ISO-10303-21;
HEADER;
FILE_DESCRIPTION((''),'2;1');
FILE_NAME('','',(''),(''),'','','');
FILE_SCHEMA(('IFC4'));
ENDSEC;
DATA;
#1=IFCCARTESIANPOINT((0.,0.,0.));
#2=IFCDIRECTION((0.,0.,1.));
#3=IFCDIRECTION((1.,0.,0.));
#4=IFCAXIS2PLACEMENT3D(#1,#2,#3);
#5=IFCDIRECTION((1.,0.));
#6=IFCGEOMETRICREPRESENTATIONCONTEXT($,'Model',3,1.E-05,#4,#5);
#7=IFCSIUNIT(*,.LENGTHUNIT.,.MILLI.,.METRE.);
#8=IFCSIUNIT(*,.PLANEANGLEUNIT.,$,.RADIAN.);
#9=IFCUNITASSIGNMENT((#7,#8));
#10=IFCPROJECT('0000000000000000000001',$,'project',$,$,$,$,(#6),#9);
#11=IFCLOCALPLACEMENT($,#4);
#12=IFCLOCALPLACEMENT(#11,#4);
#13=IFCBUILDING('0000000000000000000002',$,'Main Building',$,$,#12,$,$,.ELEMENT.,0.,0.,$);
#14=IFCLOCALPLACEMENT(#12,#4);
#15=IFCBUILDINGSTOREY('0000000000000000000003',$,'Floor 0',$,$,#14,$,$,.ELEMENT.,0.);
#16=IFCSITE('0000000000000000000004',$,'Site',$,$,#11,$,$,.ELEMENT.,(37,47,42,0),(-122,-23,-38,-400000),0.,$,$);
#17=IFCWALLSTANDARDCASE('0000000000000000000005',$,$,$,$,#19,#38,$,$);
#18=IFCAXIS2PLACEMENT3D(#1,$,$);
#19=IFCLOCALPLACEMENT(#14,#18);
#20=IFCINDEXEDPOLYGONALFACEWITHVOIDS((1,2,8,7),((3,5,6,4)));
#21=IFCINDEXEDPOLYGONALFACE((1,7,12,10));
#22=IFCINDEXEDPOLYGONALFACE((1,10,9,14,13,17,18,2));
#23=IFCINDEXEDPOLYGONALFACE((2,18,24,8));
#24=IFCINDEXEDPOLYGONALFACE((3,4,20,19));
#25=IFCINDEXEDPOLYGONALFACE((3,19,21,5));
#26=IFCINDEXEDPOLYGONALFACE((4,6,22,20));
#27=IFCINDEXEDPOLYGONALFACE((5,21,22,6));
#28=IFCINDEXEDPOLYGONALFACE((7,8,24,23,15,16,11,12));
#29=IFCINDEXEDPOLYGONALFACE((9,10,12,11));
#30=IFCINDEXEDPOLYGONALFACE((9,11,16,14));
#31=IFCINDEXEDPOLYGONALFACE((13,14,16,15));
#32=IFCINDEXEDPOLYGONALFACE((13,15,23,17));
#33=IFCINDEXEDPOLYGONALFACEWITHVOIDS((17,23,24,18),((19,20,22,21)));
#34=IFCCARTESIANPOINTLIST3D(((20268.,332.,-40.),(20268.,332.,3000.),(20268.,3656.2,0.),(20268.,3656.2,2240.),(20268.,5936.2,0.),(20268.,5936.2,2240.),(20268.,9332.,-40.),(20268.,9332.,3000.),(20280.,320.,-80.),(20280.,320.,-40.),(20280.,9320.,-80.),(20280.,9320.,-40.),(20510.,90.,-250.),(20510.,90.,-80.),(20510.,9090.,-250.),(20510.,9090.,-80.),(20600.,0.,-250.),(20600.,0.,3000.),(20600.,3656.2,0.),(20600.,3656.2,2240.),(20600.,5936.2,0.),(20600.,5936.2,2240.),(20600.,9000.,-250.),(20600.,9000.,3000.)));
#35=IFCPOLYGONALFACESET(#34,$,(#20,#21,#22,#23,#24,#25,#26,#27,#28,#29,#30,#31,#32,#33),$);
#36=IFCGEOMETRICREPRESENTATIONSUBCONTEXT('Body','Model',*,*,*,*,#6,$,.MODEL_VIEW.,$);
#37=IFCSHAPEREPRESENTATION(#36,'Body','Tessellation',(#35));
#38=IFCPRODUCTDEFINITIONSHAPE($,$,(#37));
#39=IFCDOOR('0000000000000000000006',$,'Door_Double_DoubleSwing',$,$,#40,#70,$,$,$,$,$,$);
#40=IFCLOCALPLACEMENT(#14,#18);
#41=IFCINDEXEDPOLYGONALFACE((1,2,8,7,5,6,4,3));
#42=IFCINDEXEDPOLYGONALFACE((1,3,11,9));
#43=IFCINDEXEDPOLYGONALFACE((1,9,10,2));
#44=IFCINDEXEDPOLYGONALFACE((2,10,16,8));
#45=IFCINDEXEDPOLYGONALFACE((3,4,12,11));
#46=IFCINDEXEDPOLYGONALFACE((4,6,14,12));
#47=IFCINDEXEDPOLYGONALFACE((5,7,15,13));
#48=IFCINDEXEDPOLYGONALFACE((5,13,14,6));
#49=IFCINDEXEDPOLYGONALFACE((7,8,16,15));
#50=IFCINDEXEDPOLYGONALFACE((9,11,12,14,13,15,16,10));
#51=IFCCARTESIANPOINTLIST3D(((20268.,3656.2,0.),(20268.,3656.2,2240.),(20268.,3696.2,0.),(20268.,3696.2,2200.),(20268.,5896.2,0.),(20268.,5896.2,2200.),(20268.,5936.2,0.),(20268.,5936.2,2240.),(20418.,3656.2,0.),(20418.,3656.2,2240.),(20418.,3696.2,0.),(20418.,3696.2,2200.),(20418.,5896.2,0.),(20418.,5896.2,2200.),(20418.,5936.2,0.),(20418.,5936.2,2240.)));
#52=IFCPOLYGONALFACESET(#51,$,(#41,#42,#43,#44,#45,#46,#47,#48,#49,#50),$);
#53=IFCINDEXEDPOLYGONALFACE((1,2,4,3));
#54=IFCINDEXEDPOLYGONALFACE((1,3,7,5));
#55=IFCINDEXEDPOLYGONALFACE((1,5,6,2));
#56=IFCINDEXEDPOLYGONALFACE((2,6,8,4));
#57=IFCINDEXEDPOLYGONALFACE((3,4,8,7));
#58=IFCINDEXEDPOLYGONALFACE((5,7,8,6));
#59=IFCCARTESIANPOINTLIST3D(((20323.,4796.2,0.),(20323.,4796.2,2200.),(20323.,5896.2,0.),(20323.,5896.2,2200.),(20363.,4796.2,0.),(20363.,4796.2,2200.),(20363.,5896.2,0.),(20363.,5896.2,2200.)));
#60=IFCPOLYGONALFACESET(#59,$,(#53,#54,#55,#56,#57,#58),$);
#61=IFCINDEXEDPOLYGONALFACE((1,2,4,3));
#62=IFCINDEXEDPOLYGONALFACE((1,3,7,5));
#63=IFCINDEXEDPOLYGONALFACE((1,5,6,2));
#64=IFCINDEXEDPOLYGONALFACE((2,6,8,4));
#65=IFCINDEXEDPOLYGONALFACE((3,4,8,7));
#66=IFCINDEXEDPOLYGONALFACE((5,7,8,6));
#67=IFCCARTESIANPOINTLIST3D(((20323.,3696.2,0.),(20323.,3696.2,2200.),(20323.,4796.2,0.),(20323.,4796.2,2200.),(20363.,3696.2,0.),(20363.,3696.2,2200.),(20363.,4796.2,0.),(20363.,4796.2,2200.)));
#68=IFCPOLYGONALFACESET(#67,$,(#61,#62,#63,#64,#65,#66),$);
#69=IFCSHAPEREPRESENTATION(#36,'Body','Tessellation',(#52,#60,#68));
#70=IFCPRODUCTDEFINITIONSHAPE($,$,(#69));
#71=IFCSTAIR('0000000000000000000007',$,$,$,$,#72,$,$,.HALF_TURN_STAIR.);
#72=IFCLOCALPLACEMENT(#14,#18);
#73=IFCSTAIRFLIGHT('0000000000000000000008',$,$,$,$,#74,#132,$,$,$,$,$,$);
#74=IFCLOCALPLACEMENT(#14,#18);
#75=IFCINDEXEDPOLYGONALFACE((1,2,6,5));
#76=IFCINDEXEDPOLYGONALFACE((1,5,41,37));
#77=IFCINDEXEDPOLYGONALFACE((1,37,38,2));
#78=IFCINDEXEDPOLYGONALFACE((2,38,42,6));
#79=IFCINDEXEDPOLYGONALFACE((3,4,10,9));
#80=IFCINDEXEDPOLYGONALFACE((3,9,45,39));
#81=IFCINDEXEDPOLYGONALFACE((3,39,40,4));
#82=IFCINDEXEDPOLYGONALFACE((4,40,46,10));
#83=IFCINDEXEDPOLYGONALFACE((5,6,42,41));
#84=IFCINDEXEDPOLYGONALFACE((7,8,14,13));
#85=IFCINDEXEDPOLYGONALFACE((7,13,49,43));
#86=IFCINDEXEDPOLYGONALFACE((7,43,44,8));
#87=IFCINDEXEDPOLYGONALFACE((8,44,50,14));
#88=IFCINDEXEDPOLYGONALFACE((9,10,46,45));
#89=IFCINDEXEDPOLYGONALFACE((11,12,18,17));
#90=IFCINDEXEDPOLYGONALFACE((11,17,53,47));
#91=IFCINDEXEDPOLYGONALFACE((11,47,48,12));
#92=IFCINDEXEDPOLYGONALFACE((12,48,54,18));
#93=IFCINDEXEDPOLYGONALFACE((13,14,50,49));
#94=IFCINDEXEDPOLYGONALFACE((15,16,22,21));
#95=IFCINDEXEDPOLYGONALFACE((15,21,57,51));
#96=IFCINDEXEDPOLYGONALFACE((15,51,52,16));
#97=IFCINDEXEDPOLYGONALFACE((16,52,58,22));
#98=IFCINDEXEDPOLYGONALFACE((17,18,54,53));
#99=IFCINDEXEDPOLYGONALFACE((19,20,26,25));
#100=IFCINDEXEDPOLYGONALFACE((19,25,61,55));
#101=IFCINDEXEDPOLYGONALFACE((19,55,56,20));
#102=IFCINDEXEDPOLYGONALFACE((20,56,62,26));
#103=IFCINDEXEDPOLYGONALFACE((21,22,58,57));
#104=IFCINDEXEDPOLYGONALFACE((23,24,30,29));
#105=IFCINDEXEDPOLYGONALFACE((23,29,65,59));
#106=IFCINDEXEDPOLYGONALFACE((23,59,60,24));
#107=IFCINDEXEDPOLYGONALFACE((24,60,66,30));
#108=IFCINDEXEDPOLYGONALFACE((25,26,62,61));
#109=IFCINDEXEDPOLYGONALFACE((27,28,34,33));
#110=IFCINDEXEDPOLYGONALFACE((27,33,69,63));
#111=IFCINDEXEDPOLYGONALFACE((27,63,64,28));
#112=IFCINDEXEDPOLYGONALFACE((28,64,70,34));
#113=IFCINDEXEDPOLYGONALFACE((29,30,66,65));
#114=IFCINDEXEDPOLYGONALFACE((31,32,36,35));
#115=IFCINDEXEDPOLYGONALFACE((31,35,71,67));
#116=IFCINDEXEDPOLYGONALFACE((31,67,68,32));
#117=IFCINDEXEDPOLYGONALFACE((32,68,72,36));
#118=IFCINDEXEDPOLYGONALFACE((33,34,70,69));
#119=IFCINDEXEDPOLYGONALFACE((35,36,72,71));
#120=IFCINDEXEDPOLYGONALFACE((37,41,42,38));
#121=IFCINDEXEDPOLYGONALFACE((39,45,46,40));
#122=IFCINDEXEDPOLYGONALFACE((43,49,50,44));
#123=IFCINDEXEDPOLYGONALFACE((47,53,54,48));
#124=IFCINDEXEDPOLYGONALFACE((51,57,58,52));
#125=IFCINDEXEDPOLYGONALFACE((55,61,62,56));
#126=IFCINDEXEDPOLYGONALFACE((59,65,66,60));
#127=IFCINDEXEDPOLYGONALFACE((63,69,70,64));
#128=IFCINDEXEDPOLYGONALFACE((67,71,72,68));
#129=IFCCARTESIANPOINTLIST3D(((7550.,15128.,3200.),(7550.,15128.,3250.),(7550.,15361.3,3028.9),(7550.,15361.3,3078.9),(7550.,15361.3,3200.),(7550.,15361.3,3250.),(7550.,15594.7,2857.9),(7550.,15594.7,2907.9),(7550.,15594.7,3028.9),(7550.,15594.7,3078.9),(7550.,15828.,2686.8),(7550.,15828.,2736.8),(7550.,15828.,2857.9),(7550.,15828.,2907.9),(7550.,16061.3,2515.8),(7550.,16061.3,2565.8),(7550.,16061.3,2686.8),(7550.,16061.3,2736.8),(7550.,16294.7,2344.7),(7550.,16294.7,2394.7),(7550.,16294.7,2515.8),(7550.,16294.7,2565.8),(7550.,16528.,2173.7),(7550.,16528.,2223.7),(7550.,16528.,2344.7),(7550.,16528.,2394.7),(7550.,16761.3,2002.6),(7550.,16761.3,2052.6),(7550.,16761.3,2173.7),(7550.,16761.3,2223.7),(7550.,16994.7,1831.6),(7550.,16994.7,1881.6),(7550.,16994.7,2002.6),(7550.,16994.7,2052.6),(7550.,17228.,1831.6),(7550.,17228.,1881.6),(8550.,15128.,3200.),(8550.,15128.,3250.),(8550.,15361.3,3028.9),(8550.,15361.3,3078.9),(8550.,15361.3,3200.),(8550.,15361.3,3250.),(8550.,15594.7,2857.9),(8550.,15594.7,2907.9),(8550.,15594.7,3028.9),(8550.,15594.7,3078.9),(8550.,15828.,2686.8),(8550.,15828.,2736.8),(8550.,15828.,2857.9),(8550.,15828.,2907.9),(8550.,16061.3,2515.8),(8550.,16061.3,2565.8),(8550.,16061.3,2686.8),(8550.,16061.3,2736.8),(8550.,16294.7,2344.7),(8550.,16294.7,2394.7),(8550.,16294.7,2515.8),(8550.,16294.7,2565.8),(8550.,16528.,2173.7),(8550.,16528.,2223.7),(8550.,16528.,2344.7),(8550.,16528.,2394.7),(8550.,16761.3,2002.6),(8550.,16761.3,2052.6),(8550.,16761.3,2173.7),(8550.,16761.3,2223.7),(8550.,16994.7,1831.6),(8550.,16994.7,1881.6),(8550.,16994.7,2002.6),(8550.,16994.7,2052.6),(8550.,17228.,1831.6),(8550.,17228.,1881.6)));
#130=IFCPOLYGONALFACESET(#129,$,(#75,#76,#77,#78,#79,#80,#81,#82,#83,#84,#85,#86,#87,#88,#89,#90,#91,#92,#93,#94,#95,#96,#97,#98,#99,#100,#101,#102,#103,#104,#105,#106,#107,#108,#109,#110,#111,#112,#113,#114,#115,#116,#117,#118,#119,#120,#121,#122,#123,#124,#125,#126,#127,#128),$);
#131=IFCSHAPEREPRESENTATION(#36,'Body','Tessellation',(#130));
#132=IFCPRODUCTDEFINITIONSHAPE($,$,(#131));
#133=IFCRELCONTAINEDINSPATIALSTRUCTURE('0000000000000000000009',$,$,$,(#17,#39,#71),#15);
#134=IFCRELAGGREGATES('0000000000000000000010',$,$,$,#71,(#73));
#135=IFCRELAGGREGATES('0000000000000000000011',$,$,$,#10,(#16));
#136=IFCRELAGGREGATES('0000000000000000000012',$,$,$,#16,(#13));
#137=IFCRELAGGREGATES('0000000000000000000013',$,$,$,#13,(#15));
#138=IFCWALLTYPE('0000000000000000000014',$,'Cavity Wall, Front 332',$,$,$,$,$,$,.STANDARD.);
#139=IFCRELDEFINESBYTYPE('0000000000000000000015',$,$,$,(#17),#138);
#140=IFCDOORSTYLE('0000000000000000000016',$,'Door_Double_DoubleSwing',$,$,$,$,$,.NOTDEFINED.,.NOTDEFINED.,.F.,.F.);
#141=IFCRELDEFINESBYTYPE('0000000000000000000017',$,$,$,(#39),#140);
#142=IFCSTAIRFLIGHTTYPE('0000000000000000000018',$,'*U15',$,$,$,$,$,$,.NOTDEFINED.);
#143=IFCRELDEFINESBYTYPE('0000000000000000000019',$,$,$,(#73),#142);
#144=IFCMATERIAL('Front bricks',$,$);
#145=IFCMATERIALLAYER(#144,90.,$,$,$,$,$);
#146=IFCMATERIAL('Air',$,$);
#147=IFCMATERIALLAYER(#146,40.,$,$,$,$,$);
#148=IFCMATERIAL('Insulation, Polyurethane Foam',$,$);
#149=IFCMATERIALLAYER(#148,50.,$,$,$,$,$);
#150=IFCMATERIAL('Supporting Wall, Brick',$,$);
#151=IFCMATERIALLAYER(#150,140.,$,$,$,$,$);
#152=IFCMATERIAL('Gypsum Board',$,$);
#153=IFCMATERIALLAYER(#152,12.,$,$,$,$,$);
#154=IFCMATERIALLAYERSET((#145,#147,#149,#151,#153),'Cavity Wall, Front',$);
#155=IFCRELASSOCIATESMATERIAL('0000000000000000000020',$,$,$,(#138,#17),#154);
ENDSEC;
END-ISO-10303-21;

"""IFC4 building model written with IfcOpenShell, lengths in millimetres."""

from ifc_helpers import new_model, si_unit, direction, frame, frame_2d, origin_with_axes, place, context, subcontext, project, spatial, polyline, rectangle, outline, extrude, clip, bounded_halfspace, source, transform, mapped, material, layer, layer_set, layer_usage, type_object, type_shapes, element, fill, aggregate, save


model = new_model("IFC4")

# Units and contexts
model_context = context("Model", 3, precision=1e-05, world=origin_with_axes(), true_north=direction((1.0, 0.0)))
body_context = subcontext(model_context, "Body", "Model", "MODEL_VIEW")
ifc_project = project(units=[si_unit("LENGTHUNIT", "METRE", prefix="MILLI"), si_unit("PLANEANGLEUNIT", "RADIAN")], contexts=[model_context])

# Site, building, storey
site_placement = place(None, origin_with_axes())
site = spatial("IfcSite", under=ifc_project, at=site_placement, Name="Site", CompositionType="ELEMENT", RefLatitude=(37, 47, 42, 0), RefLongitude=(-122, -23, -38, -400000), RefElevation=0.0)
building_placement = place(site_placement, origin_with_axes())
building = spatial("IfcBuilding", under=site, at=building_placement, Name="Main Building", CompositionType="ELEMENT", ElevationOfRefHeight=0.0, ElevationOfTerrain=0.0)
storey_placement = place(building_placement, origin_with_axes())
storey = spatial("IfcBuildingStorey", under=building, at=storey_placement, Name="Floor 0", CompositionType="ELEMENT", Elevation=0.0)

# Shared definitions
ifc_material_1 = material(Name="Front bricks")
ifc_layer_1 = layer(ifc_material_1, 90.0)
ifc_material_2 = material(Name="Air")
ifc_layer_2 = layer(ifc_material_2, 40.0)
ifc_material_3 = material(Name="Insulation, Polyurethane Foam")
ifc_layer_3 = layer(ifc_material_3, 50.0)
ifc_material_4 = material(Name="Supporting Wall, Brick")
ifc_layer_4 = layer(ifc_material_4, 140.0)
ifc_material_5 = material(Name="Gypsum Board")
ifc_layer_5 = layer(ifc_material_5, 12.0)
ifc_layer_set_1 = layer_set([ifc_layer_1, ifc_layer_2, ifc_layer_3, ifc_layer_4, ifc_layer_5], Name="Cavity Wall, Front")
wall_type_1 = type_object("IfcWallType", Name="Cavity Wall, Front 332", PredefinedType="STANDARD", material=ifc_layer_set_1)

# Wall, opening, door
ifc_layer_usage_1 = layer_usage(ifc_layer_set_1, "AXIS2", "POSITIVE", 0.0)
wall_1_placement = place(storey_placement, frame((20600.0, 0.0, -250.0), z_axis=(0.0, 0.0, 1.0), x_axis=(0.0, 1.0, 0.0)))
wall_1 = element("IfcWallStandardCase", 1, at=wall_1_placement, inside=storey, type_object=wall_type_1, material=ifc_layer_usage_1, context=body_context, shape_type="Clipping", body=[
    clip(clip(extrude(outline(polyline([(-4666.0, -166.0), (-4334.0, 166.0), (4666.0, 166.0), (4334.0, -166.0), (-4666.0, -166.0)])), frame((4666.0, 166.0, 0.0), z_axis=(0.0, 0.0, 1.0), x_axis=(1.0, 0.0, 0.0)), (0.0, 0.0, 1.0), 3250.0), bounded_halfspace(frame((0.0, 20600.0, 170.0), z_axis=(0.0, 0.0, -1.0), x_axis=(0.0, 1.0, 0.0)), False, frame((4666.0, 166.0, 0.0), z_axis=(0.0, 0.0, 1.0), x_axis=(1.0, 0.0, 0.0)), polyline([(-4346.0, 154.0), (4654.0, 154.0), (4424.0, -76.0), (-4576.0, -76.0), (-4346.0, 154.0)]))), bounded_halfspace(frame((0.0, 20600.0, 210.0), z_axis=(0.0, 0.0, -1.0), x_axis=(0.0, 1.0, 0.0)), False, frame((4666.0, 166.0, 0.0), z_axis=(0.0, 0.0, 1.0), x_axis=(1.0, 0.0, 0.0)), polyline([(-4334.0, 166.0), (4666.0, 166.0), (4654.0, 154.0), (-4346.0, 154.0), (-4334.0, 166.0)]))),
])
opening_1_placement = place(wall_1_placement, frame((5936.2, 332.0, 250.0), z_axis=(0.0, 0.0, 1.0), x_axis=(-1.0, 0.0, 0.0)))
opening_1 = element("IfcOpeningElement", 2, at=opening_1_placement, cuts=wall_1, ObjectType="Opening", context=body_context, shape_type="SweptSolid", body=[
    extrude(outline(polyline([(1140.0, 1120.0), (1140.0, -1120.0), (-1140.0, -1120.0), (-1140.0, 1120.0), (1140.0, 1120.0)])), frame((1140.0, 0.0, 1120.0), z_axis=(0.0, 1.0, 0.0), x_axis=(1.0, 0.0, 0.0)), (0.0, 0.0, 1.0), 1000.0),
])
door_style_1 = type_object("IfcDoorStyle", Name="Door_Double_DoubleSwing", ConstructionType="NOTDEFINED", OperationType="NOTDEFINED", ParameterTakesPrecedence=False, Sizeable=False)
shared_shape_1 = source(origin_with_axes(), body_context, "Body", "SweptSolid", [
    extrude(outline(polyline([(1140.0, -1110.0), (1100.0, -1110.0), (1100.0, 1090.0), (-1100.0, 1090.0), (-1100.0, -1110.0), (-1140.0, -1110.0), (-1140.0, 1130.0), (1140.0, 1130.0), (1140.0, -1110.0)])), frame((1140.0, 1110.0, -150.0), z_axis=(0.0, 0.0, 1.0), x_axis=(1.0, 0.0, 0.0)), (0.0, 0.0, 1.0), 150.0),
    extrude(rectangle(XDim=2200.0, YDim=1100.0, at=frame_2d((0.0, 0.0), x_axis=(0.0, 1.0))), frame((590.0, 1100.0, -95.0), z_axis=(0.0, 0.0, 1.0), x_axis=(1.0, 0.0, 0.0)), (0.0, 0.0, 1.0), 40.0),
    extrude(rectangle(XDim=2200.0, YDim=1100.0, at=frame_2d((0.0, 0.0), x_axis=(0.0, 1.0))), frame((1690.0, 1100.0, -95.0), z_axis=(0.0, 0.0, 1.0), x_axis=(1.0, 0.0, 0.0)), (0.0, 0.0, 1.0), 40.0),
])
type_shapes(door_style_1, [shared_shape_1])
door_1_placement = place(opening_1_placement, origin_with_axes())
door_1 = element("IfcDoor", 3, at=door_1_placement, inside=storey, type_object=door_style_1, Name="Door_Double_DoubleSwing", context=body_context, shape_type="MappedRepresentation", body=[
    mapped(shared_shape_1, transform((0.0, 0.0, 0.0), x_axis=(1.0, 0.0, 0.0), y_axis=(0.0, 0.0, 1.0), z_axis=(0.0, -1.0, 0.0), scale=1.0)),
])
fill(opening_1, door_1)

# Stair, stair flight
stair_placement = place(storey_placement, frame((8550.0, 15128.0, 3250.0), z_axis=(0.0, 0.0, 1.0), x_axis=(0.0, 1.0, 0.0)))
stair = element("IfcStair", 4, at=stair_placement, inside=storey, PredefinedType="HALF_TURN_STAIR")
stair_flight_type_1 = type_object("IfcStairFlightType", Name="*U15", PredefinedType="NOTDEFINED")
shared_shape_2 = source(origin_with_axes(), body_context, "Body", "SweptSolid", [
    extrude(rectangle(XDim=1000.0, YDim=233.3, at=frame_2d((0.0, 0.0), x_axis=(0.0, 1.0))), frame((116.7, 500.0, -50.0), z_axis=(0.0, 0.0, 1.0), x_axis=(1.0, 0.0, 0.0)), (0.0, 0.0, 1.0), 50.0),
])
shared_shape_3 = source(origin_with_axes(), body_context, "Body", "MappedRepresentation", [
    mapped(shared_shape_2, transform((0.0, 0.0, 0.0), x_axis=(1.0, 0.0, 0.0), y_axis=(0.0, 1.0, 0.0), z_axis=(0.0, 0.0, 1.0), scale=1.0)),
    mapped(shared_shape_2, transform((233.3, 0.0, -171.1), x_axis=(1.0, 0.0, 0.0), y_axis=(0.0, 1.0, 0.0), z_axis=(0.0, 0.0, 1.0), scale=1.0)),
    mapped(shared_shape_2, transform((466.7, 0.0, -342.1), x_axis=(1.0, 0.0, 0.0), y_axis=(0.0, 1.0, 0.0), z_axis=(0.0, 0.0, 1.0), scale=1.0)),
    mapped(shared_shape_2, transform((700.0, 0.0, -513.2), x_axis=(1.0, 0.0, 0.0), y_axis=(0.0, 1.0, 0.0), z_axis=(0.0, 0.0, 1.0), scale=1.0)),
    mapped(shared_shape_2, transform((933.3, 0.0, -684.2), x_axis=(1.0, 0.0, 0.0), y_axis=(0.0, 1.0, 0.0), z_axis=(0.0, 0.0, 1.0), scale=1.0)),
    mapped(shared_shape_2, transform((1166.7, 0.0, -855.3), x_axis=(1.0, 0.0, 0.0), y_axis=(0.0, 1.0, 0.0), z_axis=(0.0, 0.0, 1.0), scale=1.0)),
    mapped(shared_shape_2, transform((1400.0, 0.0, -1026.3), x_axis=(1.0, 0.0, 0.0), y_axis=(0.0, 1.0, 0.0), z_axis=(0.0, 0.0, 1.0), scale=1.0)),
    mapped(shared_shape_2, transform((1633.3, 0.0, -1197.4), x_axis=(1.0, 0.0, 0.0), y_axis=(0.0, 1.0, 0.0), z_axis=(0.0, 0.0, 1.0), scale=1.0)),
    mapped(shared_shape_2, transform((1866.7, 0.0, -1368.4), x_axis=(1.0, 0.0, 0.0), y_axis=(0.0, 1.0, 0.0), z_axis=(0.0, 0.0, 1.0), scale=1.0)),
])
type_shapes(stair_flight_type_1, [shared_shape_3])
stair_flight_1_placement = place(stair_placement, origin_with_axes())
stair_flight_1 = element("IfcStairFlight", 5, at=stair_flight_1_placement, type_object=stair_flight_type_1, context=body_context, shape_type="MappedRepresentation", body=[
    mapped(shared_shape_3, transform((0.0, 0.0, 0.0), x_axis=(1.0, 0.0, 0.0), y_axis=(0.0, 1.0, 0.0), z_axis=(0.0, 0.0, 1.0), scale=1.0)),
])

aggregate(stair, [stair_flight_1])

save(model, "model.ifc")
